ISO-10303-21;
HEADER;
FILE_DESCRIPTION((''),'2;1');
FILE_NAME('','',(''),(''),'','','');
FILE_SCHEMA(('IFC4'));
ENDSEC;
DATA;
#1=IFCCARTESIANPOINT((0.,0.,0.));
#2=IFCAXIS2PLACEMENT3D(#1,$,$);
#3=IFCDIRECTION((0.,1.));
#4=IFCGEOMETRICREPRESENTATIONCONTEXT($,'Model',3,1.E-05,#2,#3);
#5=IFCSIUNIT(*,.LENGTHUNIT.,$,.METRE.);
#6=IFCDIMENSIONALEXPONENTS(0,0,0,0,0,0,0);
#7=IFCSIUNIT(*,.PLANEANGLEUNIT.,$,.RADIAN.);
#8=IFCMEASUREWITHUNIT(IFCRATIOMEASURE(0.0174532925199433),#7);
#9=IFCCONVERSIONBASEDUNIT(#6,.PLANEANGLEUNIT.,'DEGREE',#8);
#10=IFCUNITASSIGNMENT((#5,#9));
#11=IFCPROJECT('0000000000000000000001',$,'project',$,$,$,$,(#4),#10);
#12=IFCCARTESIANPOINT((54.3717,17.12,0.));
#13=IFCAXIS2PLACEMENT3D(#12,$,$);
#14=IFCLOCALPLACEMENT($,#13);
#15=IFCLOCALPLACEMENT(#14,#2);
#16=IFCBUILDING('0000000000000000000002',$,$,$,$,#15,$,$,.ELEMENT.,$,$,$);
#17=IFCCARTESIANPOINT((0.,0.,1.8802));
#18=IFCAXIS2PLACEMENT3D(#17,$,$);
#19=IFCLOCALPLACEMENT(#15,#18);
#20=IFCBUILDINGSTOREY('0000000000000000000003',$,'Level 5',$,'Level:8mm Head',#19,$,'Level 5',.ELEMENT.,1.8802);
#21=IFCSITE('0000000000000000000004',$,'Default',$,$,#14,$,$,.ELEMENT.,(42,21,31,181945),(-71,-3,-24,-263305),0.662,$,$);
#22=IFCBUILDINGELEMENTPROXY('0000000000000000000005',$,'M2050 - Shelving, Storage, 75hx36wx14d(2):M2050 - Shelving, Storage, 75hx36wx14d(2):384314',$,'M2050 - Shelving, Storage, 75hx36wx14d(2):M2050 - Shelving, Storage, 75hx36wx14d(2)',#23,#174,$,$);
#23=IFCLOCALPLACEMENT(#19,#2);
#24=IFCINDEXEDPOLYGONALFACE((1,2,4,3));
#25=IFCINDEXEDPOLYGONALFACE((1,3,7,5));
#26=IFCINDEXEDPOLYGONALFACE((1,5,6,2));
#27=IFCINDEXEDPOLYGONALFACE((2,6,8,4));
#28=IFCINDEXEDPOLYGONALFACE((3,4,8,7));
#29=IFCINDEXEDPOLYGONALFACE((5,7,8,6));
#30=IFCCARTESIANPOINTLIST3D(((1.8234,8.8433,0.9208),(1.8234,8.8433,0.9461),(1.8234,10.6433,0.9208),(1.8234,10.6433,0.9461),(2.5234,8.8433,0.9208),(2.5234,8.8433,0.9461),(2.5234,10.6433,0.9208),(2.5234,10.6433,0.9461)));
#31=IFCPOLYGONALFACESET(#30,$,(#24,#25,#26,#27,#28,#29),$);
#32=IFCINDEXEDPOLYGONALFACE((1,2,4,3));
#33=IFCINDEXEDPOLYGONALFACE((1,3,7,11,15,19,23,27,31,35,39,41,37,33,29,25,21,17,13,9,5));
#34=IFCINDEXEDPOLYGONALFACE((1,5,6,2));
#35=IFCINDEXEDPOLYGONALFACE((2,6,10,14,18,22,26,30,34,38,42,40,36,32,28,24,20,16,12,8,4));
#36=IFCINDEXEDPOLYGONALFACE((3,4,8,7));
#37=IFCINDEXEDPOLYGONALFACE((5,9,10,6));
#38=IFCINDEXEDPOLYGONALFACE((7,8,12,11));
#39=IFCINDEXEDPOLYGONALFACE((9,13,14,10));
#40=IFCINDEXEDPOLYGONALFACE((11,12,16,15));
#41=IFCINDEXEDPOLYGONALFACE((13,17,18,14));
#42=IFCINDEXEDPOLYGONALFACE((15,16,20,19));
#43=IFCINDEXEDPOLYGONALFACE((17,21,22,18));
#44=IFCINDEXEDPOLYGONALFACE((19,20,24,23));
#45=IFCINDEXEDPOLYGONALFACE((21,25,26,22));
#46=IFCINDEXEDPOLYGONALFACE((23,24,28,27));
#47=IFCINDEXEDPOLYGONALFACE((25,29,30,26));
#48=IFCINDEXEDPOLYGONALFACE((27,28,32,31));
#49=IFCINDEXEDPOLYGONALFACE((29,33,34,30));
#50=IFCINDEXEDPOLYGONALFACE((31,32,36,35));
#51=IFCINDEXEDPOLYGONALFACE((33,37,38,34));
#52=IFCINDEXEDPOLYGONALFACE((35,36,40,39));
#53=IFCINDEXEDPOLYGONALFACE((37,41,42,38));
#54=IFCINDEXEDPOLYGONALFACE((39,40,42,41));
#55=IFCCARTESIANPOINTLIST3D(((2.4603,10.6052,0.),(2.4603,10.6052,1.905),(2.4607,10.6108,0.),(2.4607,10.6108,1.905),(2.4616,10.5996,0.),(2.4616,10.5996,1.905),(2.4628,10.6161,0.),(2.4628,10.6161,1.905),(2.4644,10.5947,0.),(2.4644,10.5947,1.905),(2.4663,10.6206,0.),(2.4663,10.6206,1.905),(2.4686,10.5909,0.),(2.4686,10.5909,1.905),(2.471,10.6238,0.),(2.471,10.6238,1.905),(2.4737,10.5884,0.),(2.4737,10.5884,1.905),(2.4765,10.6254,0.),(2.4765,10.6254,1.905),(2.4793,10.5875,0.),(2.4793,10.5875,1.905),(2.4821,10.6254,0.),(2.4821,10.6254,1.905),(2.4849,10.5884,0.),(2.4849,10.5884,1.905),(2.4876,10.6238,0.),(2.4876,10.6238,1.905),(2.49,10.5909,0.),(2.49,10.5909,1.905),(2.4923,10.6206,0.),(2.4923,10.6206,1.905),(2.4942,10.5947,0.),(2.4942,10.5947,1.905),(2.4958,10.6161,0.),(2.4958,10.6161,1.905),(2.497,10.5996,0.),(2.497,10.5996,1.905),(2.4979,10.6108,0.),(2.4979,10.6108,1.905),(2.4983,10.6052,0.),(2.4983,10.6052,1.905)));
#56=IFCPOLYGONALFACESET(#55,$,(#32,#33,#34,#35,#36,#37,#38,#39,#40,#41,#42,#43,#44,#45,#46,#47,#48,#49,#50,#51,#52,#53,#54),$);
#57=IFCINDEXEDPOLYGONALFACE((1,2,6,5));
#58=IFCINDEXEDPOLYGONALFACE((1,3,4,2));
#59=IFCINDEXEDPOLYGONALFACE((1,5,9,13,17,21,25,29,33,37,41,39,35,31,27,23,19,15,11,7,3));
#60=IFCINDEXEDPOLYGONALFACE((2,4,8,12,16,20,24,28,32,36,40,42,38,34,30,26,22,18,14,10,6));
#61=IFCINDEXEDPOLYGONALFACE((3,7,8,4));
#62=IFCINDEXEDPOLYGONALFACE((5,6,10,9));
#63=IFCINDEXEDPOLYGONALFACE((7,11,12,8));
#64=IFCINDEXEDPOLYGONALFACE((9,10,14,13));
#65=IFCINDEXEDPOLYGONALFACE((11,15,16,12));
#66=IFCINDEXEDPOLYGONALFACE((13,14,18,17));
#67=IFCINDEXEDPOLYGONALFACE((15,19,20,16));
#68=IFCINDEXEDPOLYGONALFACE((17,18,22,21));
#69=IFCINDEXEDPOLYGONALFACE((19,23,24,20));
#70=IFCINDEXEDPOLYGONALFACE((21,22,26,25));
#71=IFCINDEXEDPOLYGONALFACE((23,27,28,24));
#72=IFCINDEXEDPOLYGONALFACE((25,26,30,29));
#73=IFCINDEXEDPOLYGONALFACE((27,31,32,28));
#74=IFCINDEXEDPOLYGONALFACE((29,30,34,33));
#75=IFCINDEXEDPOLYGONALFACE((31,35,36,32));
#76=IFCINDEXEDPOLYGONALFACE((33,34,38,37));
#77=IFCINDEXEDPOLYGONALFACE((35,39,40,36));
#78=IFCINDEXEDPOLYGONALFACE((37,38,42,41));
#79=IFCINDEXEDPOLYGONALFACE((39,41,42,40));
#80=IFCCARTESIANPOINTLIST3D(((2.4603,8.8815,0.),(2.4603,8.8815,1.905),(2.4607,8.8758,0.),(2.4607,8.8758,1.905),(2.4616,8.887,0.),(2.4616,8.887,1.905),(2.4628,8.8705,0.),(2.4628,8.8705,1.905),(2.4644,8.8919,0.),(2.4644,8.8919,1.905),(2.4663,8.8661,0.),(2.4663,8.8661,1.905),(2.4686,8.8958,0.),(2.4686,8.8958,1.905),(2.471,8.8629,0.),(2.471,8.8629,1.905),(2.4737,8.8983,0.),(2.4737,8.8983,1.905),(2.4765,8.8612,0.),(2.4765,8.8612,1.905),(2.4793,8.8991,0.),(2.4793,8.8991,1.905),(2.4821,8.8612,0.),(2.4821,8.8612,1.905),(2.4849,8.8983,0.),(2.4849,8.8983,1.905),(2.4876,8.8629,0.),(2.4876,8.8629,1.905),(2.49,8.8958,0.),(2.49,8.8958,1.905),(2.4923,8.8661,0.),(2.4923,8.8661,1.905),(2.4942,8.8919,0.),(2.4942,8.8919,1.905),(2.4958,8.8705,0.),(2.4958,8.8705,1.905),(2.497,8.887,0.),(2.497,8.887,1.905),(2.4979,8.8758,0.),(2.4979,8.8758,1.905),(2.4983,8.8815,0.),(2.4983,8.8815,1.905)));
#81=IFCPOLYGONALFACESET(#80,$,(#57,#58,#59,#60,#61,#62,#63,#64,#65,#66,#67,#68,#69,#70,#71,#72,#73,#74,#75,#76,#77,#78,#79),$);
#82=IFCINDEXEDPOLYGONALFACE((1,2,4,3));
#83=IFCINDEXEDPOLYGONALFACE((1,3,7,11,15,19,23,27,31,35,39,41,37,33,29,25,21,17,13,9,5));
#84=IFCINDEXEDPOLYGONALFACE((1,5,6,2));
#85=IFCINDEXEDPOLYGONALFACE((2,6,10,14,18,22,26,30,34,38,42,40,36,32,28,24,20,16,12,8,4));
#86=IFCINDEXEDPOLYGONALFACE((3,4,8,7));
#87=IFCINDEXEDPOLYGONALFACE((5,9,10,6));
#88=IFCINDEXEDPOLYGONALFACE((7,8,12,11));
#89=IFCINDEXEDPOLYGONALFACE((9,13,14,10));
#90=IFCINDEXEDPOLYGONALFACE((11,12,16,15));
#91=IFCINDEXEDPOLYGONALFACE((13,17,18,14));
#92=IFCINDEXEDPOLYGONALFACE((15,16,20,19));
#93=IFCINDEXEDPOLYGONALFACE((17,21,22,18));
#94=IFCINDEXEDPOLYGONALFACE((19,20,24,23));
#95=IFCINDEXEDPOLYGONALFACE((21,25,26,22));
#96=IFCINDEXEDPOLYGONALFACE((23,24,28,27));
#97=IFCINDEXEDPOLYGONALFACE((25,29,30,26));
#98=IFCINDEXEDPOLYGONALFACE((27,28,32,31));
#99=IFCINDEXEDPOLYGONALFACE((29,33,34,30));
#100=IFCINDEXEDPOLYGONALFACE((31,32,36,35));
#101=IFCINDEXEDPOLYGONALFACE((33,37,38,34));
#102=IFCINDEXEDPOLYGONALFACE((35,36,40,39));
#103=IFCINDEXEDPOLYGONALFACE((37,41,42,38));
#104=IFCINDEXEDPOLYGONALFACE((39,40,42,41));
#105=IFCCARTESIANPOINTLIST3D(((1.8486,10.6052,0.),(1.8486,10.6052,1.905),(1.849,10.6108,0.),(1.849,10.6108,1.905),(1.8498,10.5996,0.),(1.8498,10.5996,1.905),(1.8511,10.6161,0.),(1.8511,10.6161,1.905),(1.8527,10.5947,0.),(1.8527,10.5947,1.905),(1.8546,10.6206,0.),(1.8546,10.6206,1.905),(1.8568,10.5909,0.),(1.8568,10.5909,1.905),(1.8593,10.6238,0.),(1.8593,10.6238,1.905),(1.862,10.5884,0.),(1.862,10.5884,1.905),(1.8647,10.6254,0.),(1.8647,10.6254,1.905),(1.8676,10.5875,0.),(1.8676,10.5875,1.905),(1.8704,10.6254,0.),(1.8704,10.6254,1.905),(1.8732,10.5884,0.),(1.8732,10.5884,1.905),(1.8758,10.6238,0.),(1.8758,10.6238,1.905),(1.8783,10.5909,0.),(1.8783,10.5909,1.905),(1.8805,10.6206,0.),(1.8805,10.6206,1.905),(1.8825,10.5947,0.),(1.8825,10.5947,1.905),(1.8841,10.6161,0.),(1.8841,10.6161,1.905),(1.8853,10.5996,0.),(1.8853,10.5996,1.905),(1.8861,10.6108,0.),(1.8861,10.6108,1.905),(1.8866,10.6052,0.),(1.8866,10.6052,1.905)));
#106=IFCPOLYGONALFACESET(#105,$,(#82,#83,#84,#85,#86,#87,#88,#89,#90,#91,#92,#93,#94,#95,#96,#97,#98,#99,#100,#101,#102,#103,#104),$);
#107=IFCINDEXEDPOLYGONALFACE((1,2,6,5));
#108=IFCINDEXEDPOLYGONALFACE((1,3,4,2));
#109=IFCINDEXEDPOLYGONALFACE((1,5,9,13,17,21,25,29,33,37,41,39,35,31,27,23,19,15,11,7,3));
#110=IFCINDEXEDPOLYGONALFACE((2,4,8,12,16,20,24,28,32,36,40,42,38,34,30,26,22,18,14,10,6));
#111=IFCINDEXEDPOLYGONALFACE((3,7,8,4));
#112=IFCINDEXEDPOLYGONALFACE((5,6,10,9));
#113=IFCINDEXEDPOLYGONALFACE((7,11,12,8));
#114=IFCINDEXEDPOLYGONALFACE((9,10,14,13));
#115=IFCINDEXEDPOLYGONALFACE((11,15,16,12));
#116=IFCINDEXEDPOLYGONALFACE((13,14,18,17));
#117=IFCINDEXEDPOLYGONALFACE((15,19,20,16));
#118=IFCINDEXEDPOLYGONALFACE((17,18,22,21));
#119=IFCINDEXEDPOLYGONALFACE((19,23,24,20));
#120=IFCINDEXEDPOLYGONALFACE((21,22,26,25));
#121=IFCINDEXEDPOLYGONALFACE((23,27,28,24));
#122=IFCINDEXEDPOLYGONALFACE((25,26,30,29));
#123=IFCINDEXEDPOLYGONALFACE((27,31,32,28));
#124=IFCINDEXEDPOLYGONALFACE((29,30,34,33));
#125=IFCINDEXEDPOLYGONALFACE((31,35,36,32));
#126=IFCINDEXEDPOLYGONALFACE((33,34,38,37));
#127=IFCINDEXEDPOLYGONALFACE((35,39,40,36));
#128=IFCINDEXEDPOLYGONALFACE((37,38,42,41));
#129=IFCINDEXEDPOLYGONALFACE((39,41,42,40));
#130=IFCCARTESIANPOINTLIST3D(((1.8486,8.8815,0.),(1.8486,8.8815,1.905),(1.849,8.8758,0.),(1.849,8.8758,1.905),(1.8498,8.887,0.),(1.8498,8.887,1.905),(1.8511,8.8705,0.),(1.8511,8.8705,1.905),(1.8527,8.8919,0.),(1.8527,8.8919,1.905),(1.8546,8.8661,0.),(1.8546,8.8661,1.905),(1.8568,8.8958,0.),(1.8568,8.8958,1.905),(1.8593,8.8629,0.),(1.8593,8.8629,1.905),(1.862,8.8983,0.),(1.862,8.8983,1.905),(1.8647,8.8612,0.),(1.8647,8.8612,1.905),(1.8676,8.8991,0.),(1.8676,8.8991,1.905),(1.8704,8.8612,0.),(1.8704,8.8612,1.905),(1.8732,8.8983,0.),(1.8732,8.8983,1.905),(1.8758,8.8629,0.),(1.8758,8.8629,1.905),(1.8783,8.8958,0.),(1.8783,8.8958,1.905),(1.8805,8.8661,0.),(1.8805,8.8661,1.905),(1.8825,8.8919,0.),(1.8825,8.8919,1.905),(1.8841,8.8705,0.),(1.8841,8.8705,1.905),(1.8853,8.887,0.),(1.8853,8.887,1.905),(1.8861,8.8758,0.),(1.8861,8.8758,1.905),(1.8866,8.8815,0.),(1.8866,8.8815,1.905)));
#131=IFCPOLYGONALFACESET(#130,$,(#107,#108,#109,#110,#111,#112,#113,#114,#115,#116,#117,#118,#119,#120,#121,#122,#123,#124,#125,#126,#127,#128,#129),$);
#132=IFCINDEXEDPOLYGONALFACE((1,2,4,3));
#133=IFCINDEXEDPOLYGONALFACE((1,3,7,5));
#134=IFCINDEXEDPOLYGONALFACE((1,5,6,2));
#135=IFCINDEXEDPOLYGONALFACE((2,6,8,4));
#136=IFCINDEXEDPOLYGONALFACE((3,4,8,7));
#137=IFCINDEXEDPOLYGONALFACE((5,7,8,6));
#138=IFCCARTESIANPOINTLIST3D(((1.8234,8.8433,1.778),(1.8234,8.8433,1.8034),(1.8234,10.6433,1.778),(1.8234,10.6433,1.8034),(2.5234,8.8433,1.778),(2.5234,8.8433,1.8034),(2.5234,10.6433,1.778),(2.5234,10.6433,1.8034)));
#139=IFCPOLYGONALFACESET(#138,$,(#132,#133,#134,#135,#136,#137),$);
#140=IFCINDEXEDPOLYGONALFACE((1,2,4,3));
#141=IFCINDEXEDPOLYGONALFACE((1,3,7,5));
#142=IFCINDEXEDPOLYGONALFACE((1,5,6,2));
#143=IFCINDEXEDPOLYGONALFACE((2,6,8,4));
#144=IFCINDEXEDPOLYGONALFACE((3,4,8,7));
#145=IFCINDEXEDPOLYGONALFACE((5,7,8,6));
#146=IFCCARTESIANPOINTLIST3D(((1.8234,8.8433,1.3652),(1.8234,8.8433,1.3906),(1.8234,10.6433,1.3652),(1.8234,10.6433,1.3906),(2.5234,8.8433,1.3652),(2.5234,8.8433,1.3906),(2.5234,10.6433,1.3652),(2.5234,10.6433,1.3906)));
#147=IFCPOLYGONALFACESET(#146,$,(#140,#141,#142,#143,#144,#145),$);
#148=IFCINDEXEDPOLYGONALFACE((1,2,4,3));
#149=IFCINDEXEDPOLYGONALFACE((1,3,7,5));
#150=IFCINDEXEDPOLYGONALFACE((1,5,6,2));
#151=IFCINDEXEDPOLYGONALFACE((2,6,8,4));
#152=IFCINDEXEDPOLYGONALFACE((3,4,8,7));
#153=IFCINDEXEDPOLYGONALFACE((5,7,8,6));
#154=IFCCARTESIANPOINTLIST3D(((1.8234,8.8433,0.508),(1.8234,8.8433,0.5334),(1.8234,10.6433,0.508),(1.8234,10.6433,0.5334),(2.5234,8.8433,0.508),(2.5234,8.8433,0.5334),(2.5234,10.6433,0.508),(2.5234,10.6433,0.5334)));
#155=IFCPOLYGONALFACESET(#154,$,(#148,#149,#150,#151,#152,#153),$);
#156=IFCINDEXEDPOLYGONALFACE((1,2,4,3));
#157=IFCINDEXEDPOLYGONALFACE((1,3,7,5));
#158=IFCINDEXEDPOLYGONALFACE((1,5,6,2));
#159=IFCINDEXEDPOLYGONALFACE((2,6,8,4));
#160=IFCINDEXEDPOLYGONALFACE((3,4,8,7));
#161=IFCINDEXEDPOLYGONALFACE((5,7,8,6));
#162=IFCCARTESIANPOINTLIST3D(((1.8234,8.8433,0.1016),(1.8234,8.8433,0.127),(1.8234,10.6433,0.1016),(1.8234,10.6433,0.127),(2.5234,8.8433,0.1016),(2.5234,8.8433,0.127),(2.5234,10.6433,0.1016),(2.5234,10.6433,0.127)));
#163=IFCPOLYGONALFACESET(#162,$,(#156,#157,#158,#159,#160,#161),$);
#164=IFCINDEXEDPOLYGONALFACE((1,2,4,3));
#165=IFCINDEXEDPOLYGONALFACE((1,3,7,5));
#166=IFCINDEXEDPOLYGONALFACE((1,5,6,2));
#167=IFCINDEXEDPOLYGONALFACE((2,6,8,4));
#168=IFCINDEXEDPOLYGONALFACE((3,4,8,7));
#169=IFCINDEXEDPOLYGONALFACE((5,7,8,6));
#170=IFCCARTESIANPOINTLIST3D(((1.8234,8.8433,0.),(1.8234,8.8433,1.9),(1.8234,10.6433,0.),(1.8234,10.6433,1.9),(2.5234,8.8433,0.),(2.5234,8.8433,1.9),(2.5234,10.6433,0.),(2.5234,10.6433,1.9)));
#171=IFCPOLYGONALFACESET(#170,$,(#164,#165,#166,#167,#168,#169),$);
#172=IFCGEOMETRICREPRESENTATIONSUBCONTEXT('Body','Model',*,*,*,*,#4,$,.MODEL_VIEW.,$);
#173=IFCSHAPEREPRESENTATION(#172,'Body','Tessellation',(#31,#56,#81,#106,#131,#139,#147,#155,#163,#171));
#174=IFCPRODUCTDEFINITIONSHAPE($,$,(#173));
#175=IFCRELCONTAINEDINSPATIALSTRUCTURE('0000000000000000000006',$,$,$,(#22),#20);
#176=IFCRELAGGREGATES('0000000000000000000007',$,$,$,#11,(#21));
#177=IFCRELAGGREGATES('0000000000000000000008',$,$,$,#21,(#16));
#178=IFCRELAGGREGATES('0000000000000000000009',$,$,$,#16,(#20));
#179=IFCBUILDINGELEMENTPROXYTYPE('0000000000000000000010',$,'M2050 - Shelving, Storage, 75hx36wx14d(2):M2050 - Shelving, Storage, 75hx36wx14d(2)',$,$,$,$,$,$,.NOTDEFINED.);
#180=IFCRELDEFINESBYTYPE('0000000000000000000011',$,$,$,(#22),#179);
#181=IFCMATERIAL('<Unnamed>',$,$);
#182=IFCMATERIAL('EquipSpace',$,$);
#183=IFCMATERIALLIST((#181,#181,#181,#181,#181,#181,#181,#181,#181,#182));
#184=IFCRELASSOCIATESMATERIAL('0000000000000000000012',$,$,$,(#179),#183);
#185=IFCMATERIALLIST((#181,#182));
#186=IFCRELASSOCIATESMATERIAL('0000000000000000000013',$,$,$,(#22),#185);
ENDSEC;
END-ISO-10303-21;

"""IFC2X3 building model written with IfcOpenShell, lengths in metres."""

from ifc_helpers import new_model, entity, si_unit, converted_unit, direction, frame, frame_2d, origin, origin_2d_with_axis, place, context, subcontext, project, spatial, rectangle, circle, extrude, source, transform, mapped, material, material_list, type_object, type_shapes, element, save


model = new_model("IFC2X3")

# Units and contexts
model_context = context("Model", 3, precision=1e-05, world=origin(), true_north=direction((0.0, 1.0)))
body_context = subcontext(model_context, "Body", "Model", "MODEL_VIEW")
ifc_project = project(units=[si_unit("LENGTHUNIT", "METRE"), converted_unit("PLANEANGLEUNIT", "DEGREE", entity("IfcRatioMeasure", 0.0174532925199433), si_unit("PLANEANGLEUNIT", "RADIAN"), dimensions=[0, 0, 0, 0, 0, 0, 0])], contexts=[model_context])

# Site, building, storey
site_placement = place(None, frame((54.3717, 17.12, 0.0)))
site = spatial("IfcSite", under=ifc_project, at=site_placement, Name="Default", CompositionType="ELEMENT", RefLatitude=(42, 21, 31, 181945), RefLongitude=(-71, -3, -24, -263305), RefElevation=0.662)
building_placement = place(site_placement, origin())
building = spatial("IfcBuilding", under=site, at=building_placement, CompositionType="ELEMENT")
storey_placement = place(building_placement, frame((0.0, 0.0, 1.8802)))
storey = spatial("IfcBuildingStorey", under=building, at=storey_placement, Name="Level 5", ObjectType="Level:8mm Head", LongName="Level 5", CompositionType="ELEMENT", Elevation=1.8802)

# Building element proxy
ifc_material_1 = material(Name="<Unnamed>")
ifc_material_2 = material(Name="EquipSpace")
ifc_material_list_1 = material_list([ifc_material_1, ifc_material_1, ifc_material_1, ifc_material_1, ifc_material_1, ifc_material_1, ifc_material_1, ifc_material_1, ifc_material_1, ifc_material_2])
building_element_proxy_type = type_object("IfcBuildingElementProxyType", Name="M2050 - Shelving, Storage, 75hx36wx14d(2):M2050 - Shelving, Storage, 75hx36wx14d(2)", PredefinedType="NOTDEFINED", material=ifc_material_list_1)
shared_shape = source(origin(), body_context, "Body", "SweptSolid", [
    extrude(rectangle(XDim=1.8, YDim=0.7, at=origin_2d_with_axis()), frame((0.0, 0.0, 0.9207), z_axis=(0.0, 0.0, 1.0), x_axis=(-1.0, 0.0, 0.0)), (0.0, 0.0, 1.0), 0.0254),
    extrude(circle(Radius=0.0191, at=origin_2d_with_axis()), frame((0.8633, -0.3059, 0.0), z_axis=(0.0, 0.0, 1.0), x_axis=(-1.0, 0.0, 0.0)), (0.0, 0.0, 1.0), 1.905),
    extrude(circle(Radius=0.0191, at=origin_2d_with_axis()), frame((-0.8633, -0.3059, 0.0)), (0.0, 0.0, 1.0), 1.905),
    extrude(circle(Radius=0.0191, at=origin_2d_with_axis()), frame((0.8633, 0.3059, 0.0), z_axis=(0.0, 0.0, 1.0), x_axis=(-1.0, 0.0, 0.0)), (0.0, 0.0, 1.0), 1.905),
    extrude(circle(Radius=0.0191, at=origin_2d_with_axis()), frame((-0.8633, 0.3059, 0.0)), (0.0, 0.0, 1.0), 1.905),
    extrude(rectangle(XDim=1.8, YDim=0.7, at=origin_2d_with_axis()), frame((0.0, 0.0, 1.778), z_axis=(0.0, 0.0, 1.0), x_axis=(-1.0, 0.0, 0.0)), (0.0, 0.0, 1.0), 0.0254),
    extrude(rectangle(XDim=1.8, YDim=0.7, at=origin_2d_with_axis()), frame((0.0, 0.0, 1.3653), z_axis=(0.0, 0.0, 1.0), x_axis=(-1.0, 0.0, 0.0)), (0.0, 0.0, 1.0), 0.0254),
    extrude(rectangle(XDim=1.8, YDim=0.7, at=origin_2d_with_axis()), frame((0.0, 0.0, 0.508), z_axis=(0.0, 0.0, 1.0), x_axis=(-1.0, 0.0, 0.0)), (0.0, 0.0, 1.0), 0.0254),
    extrude(rectangle(XDim=1.8, YDim=0.7, at=origin_2d_with_axis()), frame((0.0, 0.0, 0.1016), z_axis=(0.0, 0.0, 1.0), x_axis=(-1.0, 0.0, 0.0)), (0.0, 0.0, 1.0), 0.0254),
    extrude(rectangle(XDim=0.7, YDim=1.8, at=frame_2d((0.0, 0.18), x_axis=(1.0, 0.0))), frame((-0.18, 0.0, 0.0), z_axis=(0.0, 0.0, 1.0), x_axis=(0.0, -1.0, 0.0)), (0.0, 0.0, 1.0), 1.9),
])
type_shapes(building_element_proxy_type, [shared_shape])
ifc_material_list_2 = material_list([ifc_material_1, ifc_material_2])
proxy_1_placement = place(storey_placement, frame((2.1734, 9.7433, 0.0), z_axis=(0.0, 0.0, 1.0), x_axis=(0.0, 1.0, 0.0)))
element("IfcBuildingElementProxy", 1, at=proxy_1_placement, inside=storey, type_object=building_element_proxy_type, material=ifc_material_list_2, Name="M2050 - Shelving, Storage, 75hx36wx14d(2):M2050 - Shelving, Storage, 75hx36wx14d(2):384314", ObjectType="M2050 - Shelving, Storage, 75hx36wx14d(2):M2050 - Shelving, Storage, 75hx36wx14d(2)", context=body_context, shape_type="MappedRepresentation", body=[
    mapped(shared_shape, transform((0.0, 0.0, 0.0), scale=1.0)),
])

save(model, "model.ifc")
